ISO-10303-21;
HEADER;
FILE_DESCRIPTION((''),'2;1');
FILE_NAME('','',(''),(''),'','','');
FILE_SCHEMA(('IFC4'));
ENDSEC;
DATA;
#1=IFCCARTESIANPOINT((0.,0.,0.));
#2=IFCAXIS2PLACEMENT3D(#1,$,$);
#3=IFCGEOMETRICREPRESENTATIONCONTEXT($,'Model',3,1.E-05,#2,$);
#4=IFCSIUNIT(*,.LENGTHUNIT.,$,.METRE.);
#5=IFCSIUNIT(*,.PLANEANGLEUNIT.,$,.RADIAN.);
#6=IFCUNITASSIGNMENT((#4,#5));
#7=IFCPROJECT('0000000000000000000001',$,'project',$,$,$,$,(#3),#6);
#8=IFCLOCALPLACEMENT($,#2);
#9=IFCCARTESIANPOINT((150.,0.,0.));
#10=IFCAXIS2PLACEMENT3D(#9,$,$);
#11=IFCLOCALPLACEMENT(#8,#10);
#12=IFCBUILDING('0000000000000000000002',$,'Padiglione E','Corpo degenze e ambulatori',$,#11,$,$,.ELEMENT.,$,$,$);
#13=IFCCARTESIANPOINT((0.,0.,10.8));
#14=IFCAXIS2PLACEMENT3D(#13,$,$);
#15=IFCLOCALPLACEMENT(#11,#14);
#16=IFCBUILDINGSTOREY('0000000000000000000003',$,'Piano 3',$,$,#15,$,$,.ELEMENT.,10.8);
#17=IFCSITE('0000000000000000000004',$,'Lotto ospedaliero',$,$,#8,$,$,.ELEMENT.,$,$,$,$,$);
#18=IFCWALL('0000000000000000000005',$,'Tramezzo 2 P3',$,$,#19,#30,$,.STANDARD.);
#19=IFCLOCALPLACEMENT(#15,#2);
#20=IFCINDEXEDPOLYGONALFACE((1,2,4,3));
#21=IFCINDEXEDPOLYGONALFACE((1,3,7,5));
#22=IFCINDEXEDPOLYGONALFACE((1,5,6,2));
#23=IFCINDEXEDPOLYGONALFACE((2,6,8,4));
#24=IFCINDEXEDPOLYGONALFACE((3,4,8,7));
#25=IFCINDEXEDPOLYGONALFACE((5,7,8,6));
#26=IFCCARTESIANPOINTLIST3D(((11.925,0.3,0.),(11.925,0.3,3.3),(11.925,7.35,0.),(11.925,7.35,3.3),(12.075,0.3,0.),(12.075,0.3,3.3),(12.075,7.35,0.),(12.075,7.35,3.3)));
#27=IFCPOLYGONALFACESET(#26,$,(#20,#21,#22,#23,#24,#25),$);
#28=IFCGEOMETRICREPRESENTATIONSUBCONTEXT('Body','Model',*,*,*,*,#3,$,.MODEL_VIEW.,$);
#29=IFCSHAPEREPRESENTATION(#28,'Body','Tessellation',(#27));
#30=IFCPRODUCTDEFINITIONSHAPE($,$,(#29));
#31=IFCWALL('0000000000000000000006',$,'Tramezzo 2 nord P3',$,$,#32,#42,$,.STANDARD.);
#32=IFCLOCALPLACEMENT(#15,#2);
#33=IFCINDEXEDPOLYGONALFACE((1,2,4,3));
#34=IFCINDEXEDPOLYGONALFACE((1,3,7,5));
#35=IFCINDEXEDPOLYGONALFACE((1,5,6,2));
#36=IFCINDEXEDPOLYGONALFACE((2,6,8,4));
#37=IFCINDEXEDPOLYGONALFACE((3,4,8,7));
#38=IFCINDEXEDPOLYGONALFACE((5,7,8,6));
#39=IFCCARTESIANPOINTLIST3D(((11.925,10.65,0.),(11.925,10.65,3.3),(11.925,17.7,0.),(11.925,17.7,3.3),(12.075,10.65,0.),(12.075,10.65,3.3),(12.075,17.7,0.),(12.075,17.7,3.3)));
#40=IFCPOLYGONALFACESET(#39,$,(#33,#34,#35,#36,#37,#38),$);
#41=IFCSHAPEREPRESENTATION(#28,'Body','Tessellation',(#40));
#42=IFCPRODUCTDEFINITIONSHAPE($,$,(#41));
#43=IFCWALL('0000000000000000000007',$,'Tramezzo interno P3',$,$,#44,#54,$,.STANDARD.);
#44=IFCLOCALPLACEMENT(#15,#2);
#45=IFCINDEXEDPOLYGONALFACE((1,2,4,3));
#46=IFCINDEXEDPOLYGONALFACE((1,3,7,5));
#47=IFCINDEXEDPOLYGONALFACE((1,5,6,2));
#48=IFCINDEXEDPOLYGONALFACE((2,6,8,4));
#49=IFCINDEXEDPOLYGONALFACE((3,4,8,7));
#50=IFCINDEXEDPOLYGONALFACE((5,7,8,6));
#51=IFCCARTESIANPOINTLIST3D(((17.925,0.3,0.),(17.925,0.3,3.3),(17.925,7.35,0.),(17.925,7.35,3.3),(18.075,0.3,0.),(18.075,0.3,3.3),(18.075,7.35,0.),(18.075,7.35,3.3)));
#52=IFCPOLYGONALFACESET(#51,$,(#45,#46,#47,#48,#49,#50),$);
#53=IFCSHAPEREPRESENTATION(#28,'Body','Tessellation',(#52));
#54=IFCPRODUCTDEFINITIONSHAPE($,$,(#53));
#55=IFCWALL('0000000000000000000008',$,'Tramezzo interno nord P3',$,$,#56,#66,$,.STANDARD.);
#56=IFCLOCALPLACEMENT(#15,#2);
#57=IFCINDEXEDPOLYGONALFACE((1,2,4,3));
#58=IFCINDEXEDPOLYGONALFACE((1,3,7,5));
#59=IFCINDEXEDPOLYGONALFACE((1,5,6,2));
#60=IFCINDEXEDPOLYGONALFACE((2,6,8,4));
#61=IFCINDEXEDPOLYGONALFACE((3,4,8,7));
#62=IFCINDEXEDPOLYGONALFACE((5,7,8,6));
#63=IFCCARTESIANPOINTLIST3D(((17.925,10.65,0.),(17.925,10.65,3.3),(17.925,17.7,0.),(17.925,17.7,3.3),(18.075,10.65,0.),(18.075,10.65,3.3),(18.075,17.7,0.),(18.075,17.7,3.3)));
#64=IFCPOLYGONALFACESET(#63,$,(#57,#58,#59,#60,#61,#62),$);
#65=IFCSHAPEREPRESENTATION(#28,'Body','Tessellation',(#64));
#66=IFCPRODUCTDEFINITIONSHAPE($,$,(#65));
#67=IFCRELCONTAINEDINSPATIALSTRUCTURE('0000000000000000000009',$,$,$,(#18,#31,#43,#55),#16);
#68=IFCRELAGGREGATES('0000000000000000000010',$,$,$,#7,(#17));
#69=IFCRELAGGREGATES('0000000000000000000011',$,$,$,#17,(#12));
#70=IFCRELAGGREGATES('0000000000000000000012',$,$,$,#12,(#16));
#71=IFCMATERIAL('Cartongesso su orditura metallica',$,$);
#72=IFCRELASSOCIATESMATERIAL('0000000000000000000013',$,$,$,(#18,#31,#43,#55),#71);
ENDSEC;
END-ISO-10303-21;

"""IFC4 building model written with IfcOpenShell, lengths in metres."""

from ifc_helpers import new_model, si_unit, frame, frame_2d, origin, place, context, subcontext, project, spatial, rectangle, extrude, material, element, save


model = new_model("IFC4")

# Units and contexts
model_context = context("Model", 3, precision=1e-05, world=origin())
body_context = subcontext(model_context, "Body", "Model", "MODEL_VIEW")
ifc_project = project(units=[si_unit("LENGTHUNIT", "METRE"), si_unit("PLANEANGLEUNIT", "RADIAN")], contexts=[model_context])

# Site, building, storey
site_placement = place(None, origin())
site = spatial("IfcSite", under=ifc_project, at=site_placement, Name="Lotto ospedaliero", CompositionType="ELEMENT")
building_placement = place(site_placement, frame((150.0, 0.0, 0.0)))
building = spatial("IfcBuilding", under=site, at=building_placement, Name="Padiglione E", Description="Corpo degenze e ambulatori", CompositionType="ELEMENT")
storey_placement = place(building_placement, frame((0.0, 0.0, 10.8)))
storey = spatial("IfcBuildingStorey", under=building, at=storey_placement, Name="Piano 3", CompositionType="ELEMENT", Elevation=10.8)

# Walls
ifc_material_1 = material(Name="Cartongesso su orditura metallica")
for number, where, name in (
    (1, (11.925, 0.3, 0.0), "Tramezzo 2 P3"),
    (2, (11.925, 10.65, 0.0), "Tramezzo 2 nord P3"),
    (3, (17.925, 0.3, 0.0), "Tramezzo interno P3"),
    (4, (17.925, 10.65, 0.0), "Tramezzo interno nord P3"),
):
    element("IfcWall", number, at=place(storey_placement, frame(where)), inside=storey, material=ifc_material_1, Name=name, PredefinedType="STANDARD", context=body_context, shape_type="SweptSolid", body=[
        extrude(rectangle(XDim=0.15, YDim=7.05, at=frame_2d((0.075, 3.525))), origin(), (0.0, 0.0, 1.0), 3.3),
    ])

save(model, "model.ifc")
